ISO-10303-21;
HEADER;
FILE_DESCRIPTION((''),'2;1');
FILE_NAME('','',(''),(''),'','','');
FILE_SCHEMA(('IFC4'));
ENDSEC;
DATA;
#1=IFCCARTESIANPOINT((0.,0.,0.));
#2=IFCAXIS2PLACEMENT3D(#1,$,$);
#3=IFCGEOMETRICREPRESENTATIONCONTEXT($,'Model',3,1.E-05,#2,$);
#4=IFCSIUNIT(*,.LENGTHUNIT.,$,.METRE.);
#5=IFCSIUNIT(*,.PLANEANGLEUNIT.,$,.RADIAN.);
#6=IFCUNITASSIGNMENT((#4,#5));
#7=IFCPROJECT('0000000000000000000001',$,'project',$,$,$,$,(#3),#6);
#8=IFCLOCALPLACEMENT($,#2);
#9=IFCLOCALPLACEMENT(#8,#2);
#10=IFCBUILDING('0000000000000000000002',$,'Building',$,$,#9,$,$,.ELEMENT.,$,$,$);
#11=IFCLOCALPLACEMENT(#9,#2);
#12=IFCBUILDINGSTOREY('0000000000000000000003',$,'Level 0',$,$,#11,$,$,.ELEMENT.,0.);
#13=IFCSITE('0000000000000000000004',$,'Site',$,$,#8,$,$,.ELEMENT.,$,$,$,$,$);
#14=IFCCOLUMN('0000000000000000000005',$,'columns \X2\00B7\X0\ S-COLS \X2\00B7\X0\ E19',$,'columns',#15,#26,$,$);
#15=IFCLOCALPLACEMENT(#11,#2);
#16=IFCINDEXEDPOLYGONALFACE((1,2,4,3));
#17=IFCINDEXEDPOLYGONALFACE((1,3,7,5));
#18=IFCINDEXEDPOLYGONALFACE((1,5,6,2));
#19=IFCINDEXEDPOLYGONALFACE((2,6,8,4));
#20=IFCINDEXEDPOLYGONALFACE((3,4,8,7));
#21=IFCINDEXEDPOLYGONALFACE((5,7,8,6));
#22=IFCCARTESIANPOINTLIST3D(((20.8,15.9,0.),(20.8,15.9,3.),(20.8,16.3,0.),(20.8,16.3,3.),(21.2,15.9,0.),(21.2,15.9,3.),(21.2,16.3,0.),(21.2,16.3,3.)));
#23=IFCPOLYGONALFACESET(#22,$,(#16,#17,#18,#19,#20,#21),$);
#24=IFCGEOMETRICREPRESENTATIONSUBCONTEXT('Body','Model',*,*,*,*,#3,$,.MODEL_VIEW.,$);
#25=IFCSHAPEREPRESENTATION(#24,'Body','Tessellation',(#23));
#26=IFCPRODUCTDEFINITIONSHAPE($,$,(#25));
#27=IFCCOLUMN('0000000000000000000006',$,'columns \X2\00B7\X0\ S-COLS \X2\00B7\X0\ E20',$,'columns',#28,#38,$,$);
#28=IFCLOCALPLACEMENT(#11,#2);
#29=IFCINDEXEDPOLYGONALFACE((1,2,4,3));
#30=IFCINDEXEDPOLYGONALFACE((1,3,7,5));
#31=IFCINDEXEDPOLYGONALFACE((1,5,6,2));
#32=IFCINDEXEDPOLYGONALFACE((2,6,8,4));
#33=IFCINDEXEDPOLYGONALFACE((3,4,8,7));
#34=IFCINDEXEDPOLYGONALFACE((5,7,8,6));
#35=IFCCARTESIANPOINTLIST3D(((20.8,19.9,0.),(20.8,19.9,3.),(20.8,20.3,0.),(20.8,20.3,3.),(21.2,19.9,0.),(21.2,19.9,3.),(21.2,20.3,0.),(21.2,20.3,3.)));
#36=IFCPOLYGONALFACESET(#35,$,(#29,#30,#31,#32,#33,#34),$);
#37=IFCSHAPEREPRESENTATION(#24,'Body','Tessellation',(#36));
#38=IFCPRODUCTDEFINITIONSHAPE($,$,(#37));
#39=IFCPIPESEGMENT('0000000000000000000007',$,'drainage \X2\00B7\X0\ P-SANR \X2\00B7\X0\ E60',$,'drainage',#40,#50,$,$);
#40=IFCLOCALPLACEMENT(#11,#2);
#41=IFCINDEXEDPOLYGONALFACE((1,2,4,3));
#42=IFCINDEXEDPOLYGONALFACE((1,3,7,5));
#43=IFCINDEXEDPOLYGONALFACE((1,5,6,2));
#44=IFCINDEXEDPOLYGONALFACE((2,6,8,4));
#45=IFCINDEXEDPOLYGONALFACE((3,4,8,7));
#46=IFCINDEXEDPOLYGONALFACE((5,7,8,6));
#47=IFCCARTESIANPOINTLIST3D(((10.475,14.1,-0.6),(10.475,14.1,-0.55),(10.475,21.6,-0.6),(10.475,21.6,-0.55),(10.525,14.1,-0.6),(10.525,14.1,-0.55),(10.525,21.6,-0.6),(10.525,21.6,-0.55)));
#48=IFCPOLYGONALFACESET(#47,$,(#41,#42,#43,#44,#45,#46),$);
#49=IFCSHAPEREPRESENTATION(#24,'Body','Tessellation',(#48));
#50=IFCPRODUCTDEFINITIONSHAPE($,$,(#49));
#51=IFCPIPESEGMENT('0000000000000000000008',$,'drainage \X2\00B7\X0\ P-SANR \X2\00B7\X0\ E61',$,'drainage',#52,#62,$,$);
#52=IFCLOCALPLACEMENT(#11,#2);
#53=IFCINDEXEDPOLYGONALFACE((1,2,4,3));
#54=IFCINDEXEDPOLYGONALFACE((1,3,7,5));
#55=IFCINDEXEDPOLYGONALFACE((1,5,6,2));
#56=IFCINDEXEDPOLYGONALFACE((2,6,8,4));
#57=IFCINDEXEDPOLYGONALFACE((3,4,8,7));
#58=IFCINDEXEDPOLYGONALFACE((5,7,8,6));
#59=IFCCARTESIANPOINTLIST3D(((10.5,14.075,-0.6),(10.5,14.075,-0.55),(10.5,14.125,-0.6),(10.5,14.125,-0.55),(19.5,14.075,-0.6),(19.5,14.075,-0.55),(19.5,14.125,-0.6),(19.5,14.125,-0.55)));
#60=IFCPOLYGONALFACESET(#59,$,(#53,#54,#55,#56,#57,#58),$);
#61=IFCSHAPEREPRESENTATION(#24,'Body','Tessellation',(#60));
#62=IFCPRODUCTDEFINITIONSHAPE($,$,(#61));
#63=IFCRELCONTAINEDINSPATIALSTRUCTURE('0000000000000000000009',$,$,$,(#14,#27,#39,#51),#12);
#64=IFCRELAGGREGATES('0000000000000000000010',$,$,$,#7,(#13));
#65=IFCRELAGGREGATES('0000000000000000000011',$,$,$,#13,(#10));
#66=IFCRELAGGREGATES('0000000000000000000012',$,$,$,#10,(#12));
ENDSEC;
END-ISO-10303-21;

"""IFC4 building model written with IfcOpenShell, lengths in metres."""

from ifc_helpers import new_model, si_unit, frame, origin, place, context, subcontext, project, spatial, polyline, outline, extrude, element, save


model = new_model("IFC4")

# Units and contexts
model_context = context("Model", 3, precision=1e-05, world=origin())
body_context = subcontext(model_context, "Body", "Model", "MODEL_VIEW")
ifc_project = project(units=[si_unit("LENGTHUNIT", "METRE"), si_unit("PLANEANGLEUNIT", "RADIAN")], contexts=[model_context])

# Site, building, storey
site_placement = place(None, origin())
site = spatial("IfcSite", under=ifc_project, at=site_placement, Name="Site", CompositionType="ELEMENT")
building_placement = place(site_placement, origin())
building = spatial("IfcBuilding", under=site, at=building_placement, Name="Building", CompositionType="ELEMENT")
storey_placement = place(building_placement, origin())
storey = spatial("IfcBuildingStorey", under=building, at=storey_placement, Name="Level 0", CompositionType="ELEMENT", Elevation=0.0)

# Columns
column_1_placement = place(storey_placement, origin())
element("IfcColumn", 1, at=column_1_placement, inside=storey, Name="columns · S-COLS · E19", ObjectType="columns", context=body_context, shape_type="SweptSolid", body=[
    extrude(outline(polyline([(20.8, 15.9), (21.2, 15.9), (21.2, 16.3), (20.8, 16.3), (20.8, 15.9)])), origin(), (0.0, 0.0, 1.0), 3.0),
])
column_2_placement = place(storey_placement, origin())
element("IfcColumn", 2, at=column_2_placement, inside=storey, Name="columns · S-COLS · E20", ObjectType="columns", context=body_context, shape_type="SweptSolid", body=[
    extrude(outline(polyline([(20.8, 19.9), (21.2, 19.9), (21.2, 20.3), (20.8, 20.3), (20.8, 19.9)])), origin(), (0.0, 0.0, 1.0), 3.0),
])

# Pipe segments
pipe_segment_1_placement = place(storey_placement, frame((0.0, 0.0, -0.6)))
element("IfcPipeSegment", 3, at=pipe_segment_1_placement, inside=storey, Name="drainage · P-SANR · E60", ObjectType="drainage", context=body_context, shape_type="SweptSolid", body=[
    extrude(outline(polyline([(10.475, 21.6), (10.475, 14.1), (10.525, 14.1), (10.525, 21.6), (10.475, 21.6)])), origin(), (0.0, 0.0, 1.0), 0.05),
])
pipe_segment_2_placement = place(storey_placement, frame((0.0, 0.0, -0.6)))
element("IfcPipeSegment", 4, at=pipe_segment_2_placement, inside=storey, Name="drainage · P-SANR · E61", ObjectType="drainage", context=body_context, shape_type="SweptSolid", body=[
    extrude(outline(polyline([(10.5, 14.075), (19.5, 14.075), (19.5, 14.125), (10.5, 14.125), (10.5, 14.075)])), origin(), (0.0, 0.0, 1.0), 0.05),
])

save(model, "model.ifc")
